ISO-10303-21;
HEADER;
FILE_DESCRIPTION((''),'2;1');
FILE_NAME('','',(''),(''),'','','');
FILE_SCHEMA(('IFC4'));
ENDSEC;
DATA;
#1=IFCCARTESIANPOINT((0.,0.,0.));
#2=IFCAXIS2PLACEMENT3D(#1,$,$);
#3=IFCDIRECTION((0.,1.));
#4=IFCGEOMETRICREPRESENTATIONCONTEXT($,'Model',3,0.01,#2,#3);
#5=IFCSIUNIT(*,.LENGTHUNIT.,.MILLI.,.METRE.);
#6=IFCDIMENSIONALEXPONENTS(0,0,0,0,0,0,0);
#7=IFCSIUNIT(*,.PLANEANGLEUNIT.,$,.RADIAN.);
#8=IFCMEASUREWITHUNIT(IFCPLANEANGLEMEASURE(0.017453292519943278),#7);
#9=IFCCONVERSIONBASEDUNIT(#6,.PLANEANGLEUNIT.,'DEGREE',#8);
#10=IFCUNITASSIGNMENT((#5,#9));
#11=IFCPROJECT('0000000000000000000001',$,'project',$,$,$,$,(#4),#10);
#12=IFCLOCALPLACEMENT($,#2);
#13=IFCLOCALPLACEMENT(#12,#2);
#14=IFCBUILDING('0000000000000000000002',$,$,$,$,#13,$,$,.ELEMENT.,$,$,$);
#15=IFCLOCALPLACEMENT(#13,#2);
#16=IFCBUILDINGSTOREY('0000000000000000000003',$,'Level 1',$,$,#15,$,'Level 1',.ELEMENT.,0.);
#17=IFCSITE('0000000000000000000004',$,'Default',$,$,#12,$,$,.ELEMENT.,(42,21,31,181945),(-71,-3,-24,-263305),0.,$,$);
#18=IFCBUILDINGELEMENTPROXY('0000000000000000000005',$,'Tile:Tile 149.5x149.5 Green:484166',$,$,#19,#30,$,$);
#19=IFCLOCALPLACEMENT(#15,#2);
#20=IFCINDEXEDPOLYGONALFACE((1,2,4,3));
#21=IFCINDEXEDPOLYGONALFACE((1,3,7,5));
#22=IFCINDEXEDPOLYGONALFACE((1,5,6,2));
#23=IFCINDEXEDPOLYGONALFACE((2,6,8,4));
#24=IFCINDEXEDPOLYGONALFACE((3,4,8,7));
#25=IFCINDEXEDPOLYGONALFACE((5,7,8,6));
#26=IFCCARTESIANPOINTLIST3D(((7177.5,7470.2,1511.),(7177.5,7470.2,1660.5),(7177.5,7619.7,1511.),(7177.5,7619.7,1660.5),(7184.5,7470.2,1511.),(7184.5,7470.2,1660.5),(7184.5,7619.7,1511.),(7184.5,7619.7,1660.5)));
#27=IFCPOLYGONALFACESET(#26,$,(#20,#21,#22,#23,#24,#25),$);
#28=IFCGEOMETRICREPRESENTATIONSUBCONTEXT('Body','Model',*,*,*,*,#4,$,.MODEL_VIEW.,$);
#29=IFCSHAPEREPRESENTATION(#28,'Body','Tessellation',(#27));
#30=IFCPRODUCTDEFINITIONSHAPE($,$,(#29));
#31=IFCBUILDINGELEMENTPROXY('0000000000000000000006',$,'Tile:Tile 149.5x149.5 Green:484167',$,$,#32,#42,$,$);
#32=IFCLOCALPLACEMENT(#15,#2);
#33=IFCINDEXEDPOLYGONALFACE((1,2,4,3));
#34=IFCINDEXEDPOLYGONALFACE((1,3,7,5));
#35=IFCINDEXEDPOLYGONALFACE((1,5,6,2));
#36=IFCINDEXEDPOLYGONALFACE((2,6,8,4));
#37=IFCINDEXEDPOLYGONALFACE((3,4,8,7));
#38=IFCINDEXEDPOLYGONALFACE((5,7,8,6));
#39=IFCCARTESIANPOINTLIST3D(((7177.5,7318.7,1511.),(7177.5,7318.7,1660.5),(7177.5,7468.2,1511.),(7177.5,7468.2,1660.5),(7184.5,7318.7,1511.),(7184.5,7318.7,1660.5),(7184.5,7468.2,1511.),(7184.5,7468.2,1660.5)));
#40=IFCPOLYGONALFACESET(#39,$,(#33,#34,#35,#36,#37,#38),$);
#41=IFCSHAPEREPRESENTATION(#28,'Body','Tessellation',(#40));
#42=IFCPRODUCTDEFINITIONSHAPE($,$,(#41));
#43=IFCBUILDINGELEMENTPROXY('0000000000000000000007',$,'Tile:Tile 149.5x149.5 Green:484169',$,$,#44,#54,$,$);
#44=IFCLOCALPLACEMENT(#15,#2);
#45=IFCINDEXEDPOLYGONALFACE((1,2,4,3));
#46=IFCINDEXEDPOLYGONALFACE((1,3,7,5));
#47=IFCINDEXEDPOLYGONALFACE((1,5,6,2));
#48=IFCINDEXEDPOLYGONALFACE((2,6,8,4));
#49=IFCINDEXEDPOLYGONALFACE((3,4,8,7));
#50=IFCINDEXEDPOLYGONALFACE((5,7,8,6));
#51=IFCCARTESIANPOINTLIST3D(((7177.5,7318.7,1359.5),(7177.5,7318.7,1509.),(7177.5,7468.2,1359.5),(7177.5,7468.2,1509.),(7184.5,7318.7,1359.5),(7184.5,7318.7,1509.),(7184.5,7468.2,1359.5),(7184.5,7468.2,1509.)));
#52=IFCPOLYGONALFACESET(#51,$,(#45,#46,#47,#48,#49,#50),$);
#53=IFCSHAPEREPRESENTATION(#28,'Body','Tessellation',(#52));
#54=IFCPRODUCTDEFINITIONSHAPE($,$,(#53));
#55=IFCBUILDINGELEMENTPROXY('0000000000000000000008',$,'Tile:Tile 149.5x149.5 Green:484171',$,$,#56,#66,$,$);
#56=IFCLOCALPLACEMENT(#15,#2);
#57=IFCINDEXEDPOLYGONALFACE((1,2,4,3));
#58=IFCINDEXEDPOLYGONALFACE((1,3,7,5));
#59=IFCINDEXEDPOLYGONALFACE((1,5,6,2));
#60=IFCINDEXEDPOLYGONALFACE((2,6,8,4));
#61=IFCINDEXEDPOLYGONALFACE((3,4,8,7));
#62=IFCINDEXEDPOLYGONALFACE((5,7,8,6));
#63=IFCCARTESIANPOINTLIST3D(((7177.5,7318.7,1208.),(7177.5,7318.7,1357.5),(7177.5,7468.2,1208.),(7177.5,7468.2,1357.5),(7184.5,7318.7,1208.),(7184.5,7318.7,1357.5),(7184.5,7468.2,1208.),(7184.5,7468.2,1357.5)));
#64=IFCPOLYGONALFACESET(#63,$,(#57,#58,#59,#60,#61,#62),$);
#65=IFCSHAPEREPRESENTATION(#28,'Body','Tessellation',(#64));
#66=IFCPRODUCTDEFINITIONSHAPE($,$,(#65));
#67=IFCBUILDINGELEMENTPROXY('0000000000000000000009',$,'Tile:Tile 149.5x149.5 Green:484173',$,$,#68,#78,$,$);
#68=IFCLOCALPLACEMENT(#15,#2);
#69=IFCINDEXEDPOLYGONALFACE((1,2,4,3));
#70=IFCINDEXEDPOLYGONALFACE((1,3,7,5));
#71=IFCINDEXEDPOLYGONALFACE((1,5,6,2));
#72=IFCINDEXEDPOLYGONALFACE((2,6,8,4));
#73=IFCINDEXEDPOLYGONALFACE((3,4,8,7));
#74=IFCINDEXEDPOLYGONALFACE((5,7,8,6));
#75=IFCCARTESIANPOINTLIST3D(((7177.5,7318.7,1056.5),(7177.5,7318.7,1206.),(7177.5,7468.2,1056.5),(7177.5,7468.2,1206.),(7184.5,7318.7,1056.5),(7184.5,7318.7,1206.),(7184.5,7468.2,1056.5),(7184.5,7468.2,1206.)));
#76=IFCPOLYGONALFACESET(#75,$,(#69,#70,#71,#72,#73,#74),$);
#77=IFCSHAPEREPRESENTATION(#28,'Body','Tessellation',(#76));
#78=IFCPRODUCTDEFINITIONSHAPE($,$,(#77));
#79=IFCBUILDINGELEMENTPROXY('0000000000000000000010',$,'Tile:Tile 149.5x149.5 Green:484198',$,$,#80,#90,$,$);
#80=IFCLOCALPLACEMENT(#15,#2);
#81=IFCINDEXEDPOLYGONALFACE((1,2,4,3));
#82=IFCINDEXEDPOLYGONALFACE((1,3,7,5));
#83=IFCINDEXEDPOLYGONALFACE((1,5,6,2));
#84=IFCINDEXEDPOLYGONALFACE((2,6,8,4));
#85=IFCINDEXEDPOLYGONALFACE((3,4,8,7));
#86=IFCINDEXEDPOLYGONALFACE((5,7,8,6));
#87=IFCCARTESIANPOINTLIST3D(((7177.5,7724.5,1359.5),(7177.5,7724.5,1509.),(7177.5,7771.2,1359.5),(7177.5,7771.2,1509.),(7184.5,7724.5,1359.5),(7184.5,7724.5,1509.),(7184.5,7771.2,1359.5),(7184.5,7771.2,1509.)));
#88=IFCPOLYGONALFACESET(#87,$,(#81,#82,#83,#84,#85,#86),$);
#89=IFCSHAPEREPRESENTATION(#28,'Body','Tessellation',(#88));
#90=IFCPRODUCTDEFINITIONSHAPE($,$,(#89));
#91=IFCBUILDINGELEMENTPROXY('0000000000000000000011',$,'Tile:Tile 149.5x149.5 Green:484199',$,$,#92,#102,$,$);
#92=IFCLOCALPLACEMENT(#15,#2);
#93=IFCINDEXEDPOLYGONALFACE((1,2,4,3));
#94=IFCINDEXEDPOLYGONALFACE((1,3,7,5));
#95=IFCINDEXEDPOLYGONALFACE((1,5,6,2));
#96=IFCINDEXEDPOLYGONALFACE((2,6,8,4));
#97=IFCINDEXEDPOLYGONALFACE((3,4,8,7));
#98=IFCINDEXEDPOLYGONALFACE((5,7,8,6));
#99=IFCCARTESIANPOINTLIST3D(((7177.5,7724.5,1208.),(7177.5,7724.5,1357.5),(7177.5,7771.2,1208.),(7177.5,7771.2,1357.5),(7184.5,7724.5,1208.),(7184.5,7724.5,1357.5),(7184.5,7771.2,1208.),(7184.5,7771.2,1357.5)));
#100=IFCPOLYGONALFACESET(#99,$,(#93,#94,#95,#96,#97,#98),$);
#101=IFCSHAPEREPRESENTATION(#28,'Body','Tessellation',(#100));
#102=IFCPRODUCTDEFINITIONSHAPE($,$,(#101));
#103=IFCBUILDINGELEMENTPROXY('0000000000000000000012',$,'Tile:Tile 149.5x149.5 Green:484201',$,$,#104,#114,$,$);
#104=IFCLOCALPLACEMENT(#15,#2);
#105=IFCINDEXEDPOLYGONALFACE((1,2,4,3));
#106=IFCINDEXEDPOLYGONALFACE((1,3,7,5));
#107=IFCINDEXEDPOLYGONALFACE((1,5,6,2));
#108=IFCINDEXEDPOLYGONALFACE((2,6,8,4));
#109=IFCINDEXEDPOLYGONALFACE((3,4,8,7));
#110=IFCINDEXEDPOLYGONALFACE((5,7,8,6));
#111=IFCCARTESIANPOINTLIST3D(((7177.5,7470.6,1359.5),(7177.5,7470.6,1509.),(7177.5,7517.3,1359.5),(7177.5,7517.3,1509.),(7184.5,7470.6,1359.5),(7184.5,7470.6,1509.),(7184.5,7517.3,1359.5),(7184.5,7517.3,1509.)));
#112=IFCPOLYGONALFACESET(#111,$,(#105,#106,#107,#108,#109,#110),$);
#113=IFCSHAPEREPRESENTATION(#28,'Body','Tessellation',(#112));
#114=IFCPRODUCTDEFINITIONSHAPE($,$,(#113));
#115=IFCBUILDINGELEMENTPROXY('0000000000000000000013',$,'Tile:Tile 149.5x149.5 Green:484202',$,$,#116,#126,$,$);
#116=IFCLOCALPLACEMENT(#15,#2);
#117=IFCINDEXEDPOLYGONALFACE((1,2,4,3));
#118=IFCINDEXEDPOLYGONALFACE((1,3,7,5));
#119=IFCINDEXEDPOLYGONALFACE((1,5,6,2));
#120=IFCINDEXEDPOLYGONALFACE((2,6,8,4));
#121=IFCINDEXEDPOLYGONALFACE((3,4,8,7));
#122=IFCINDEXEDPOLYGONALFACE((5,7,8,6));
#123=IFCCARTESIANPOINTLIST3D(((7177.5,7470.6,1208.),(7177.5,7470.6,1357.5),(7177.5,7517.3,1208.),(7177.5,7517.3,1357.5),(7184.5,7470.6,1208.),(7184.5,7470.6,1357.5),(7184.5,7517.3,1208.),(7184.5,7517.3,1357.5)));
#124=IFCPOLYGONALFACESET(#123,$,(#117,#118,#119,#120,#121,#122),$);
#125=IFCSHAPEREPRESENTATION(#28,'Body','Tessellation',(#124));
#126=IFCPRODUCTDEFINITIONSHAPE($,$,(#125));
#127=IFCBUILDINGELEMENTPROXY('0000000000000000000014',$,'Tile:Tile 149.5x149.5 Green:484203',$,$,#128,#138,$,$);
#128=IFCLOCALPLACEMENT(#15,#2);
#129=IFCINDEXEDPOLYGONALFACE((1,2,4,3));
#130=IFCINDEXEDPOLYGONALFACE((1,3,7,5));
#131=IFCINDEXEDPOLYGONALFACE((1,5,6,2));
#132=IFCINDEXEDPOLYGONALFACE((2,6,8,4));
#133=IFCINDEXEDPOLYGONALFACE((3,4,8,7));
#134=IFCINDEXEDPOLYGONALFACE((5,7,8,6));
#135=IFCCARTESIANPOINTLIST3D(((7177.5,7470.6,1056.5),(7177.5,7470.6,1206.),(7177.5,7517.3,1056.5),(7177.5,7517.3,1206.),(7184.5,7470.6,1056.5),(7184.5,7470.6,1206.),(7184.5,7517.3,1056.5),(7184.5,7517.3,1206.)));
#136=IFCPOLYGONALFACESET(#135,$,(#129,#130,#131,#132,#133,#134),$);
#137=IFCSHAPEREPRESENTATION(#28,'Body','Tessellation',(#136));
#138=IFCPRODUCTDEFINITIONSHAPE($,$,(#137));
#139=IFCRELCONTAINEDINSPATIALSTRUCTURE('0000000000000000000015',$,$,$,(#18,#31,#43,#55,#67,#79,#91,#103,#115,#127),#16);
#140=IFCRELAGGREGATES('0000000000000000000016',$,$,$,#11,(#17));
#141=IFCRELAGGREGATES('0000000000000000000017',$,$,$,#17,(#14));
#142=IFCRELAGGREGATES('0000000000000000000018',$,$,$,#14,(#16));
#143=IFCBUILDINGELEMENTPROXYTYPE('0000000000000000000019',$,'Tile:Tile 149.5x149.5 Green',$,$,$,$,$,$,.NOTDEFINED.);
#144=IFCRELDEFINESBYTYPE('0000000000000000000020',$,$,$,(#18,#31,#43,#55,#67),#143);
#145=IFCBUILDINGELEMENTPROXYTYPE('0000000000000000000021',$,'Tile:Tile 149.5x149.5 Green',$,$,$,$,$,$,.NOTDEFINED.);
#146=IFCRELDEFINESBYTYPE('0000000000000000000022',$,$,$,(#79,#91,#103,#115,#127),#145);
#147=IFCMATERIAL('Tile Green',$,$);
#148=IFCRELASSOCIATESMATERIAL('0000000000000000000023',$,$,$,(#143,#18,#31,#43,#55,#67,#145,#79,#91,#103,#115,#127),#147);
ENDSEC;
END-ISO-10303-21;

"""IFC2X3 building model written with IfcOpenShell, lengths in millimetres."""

from ifc_helpers import new_model, entity, si_unit, converted_unit, direction, frame, origin, origin_2d_with_axis, place, context, subcontext, project, spatial, rectangle, extrude, source, transform, mapped, material, type_object, type_shapes, element, save


model = new_model("IFC2X3")

# Units and contexts
model_context = context("Model", 3, precision=0.01, world=origin(), true_north=direction((0.0, 1.0)))
body_context = subcontext(model_context, "Body", "Model", "MODEL_VIEW")
ifc_project = project(units=[si_unit("LENGTHUNIT", "METRE", prefix="MILLI"), converted_unit("PLANEANGLEUNIT", "DEGREE", entity("IfcPlaneAngleMeasure", 0.017453292519943278), si_unit("PLANEANGLEUNIT", "RADIAN"), dimensions=[0, 0, 0, 0, 0, 0, 0])], contexts=[model_context])

# Site, building, storey
site_placement = place(None, origin())
site = spatial("IfcSite", under=ifc_project, at=site_placement, Name="Default", CompositionType="ELEMENT", RefLatitude=(42, 21, 31, 181945), RefLongitude=(-71, -3, -24, -263305), RefElevation=0.0)
building_placement = place(site_placement, origin())
building = spatial("IfcBuilding", under=site, at=building_placement, CompositionType="ELEMENT")
storey_placement = place(building_placement, origin())
storey = spatial("IfcBuildingStorey", under=building, at=storey_placement, Name="Level 1", LongName="Level 1", CompositionType="ELEMENT", Elevation=0.0)

# Building element proxies
ifc_material_1 = material(Name="Tile Green")
building_element_proxy_type_1 = type_object("IfcBuildingElementProxyType", Name="Tile:Tile 149.5x149.5 Green", PredefinedType="NOTDEFINED", material=ifc_material_1)
shared_shape_1 = source(origin(), body_context, "Body", "SweptSolid", [
    extrude(rectangle(XDim=149.5, YDim=149.5, at=origin_2d_with_axis()), frame((-74.7, -74.8, 0.0), z_axis=(0.0, 0.0, 1.0), x_axis=(0.0, -1.0, 0.0)), (0.0, 0.0, 1.0), 7.0),
])
type_shapes(building_element_proxy_type_1, [shared_shape_1])
for number, where, z_axis, x_axis, name in (
    (1, (7184.5, 7619.7, 1660.5), (-1.0, 0.0, 0.0), (0.0, 0.0, 1.0), "Tile:Tile 149.5x149.5 Green:484166"),
    (2, (7184.5, 7468.2, 1660.5), (-1.0, 0.0, 0.0), (0.0, 0.0, 1.0), "Tile:Tile 149.5x149.5 Green:484167"),
    (3, (7184.5, 7468.2, 1509.0), (-1.0, 0.0, 0.0), (0.0, 0.0, 1.0), "Tile:Tile 149.5x149.5 Green:484169"),
    (4, (7184.5, 7468.2, 1357.5), (-1.0, 0.0, 0.0), (0.0, 0.0, 1.0), "Tile:Tile 149.5x149.5 Green:484171"),
    (5, (7184.5, 7468.2, 1206.0), (-1.0, 0.0, 0.0), (0.0, 0.0, 1.0), "Tile:Tile 149.5x149.5 Green:484173"),
):
    element("IfcBuildingElementProxy", number, at=place(storey_placement, frame(where, z_axis=z_axis, x_axis=x_axis)), inside=storey, type_object=building_element_proxy_type_1, material=ifc_material_1, Name=name, context=body_context, shape_type="MappedRepresentation", body=[
        mapped(shared_shape_1, transform((0.0, 0.0, 0.0), scale=1.0)),
    ])
building_element_proxy_type_2 = type_object("IfcBuildingElementProxyType", Name="Tile:Tile 149.5x149.5 Green", PredefinedType="NOTDEFINED", material=ifc_material_1)
shared_shape_2 = source(origin(), body_context, "Body", "SweptSolid", [
    extrude(rectangle(XDim=46.7, YDim=149.5, at=origin_2d_with_axis()), frame((-23.3, -74.8, 0.0), z_axis=(0.0, 0.0, 1.0), x_axis=(-1.0, 0.0, 0.0)), (0.0, 0.0, 1.0), 7.0),
])
type_shapes(building_element_proxy_type_2, [shared_shape_2])
for number, where, z_axis, x_axis, name in (
    (6, (7184.5, 7771.2, 1359.5), (-1.0, 0.0, 0.0), (0.0, 1.0, 0.0), "Tile:Tile 149.5x149.5 Green:484198"),
    (7, (7184.5, 7771.2, 1208.0), (-1.0, 0.0, 0.0), (0.0, 1.0, 0.0), "Tile:Tile 149.5x149.5 Green:484199"),
    (8, (7184.5, 7517.3, 1359.5), (-1.0, 0.0, 0.0), (0.0, 1.0, 0.0), "Tile:Tile 149.5x149.5 Green:484201"),
    (9, (7184.5, 7517.3, 1208.0), (-1.0, 0.0, 0.0), (0.0, 1.0, 0.0), "Tile:Tile 149.5x149.5 Green:484202"),
    (10, (7184.5, 7517.3, 1056.5), (-1.0, 0.0, 0.0), (0.0, 1.0, 0.0), "Tile:Tile 149.5x149.5 Green:484203"),
):
    element("IfcBuildingElementProxy", number, at=place(storey_placement, frame(where, z_axis=z_axis, x_axis=x_axis)), inside=storey, type_object=building_element_proxy_type_2, material=ifc_material_1, Name=name, context=body_context, shape_type="MappedRepresentation", body=[
        mapped(shared_shape_2, transform((0.0, 0.0, 0.0), scale=1.0)),
    ])

save(model, "model.ifc")
